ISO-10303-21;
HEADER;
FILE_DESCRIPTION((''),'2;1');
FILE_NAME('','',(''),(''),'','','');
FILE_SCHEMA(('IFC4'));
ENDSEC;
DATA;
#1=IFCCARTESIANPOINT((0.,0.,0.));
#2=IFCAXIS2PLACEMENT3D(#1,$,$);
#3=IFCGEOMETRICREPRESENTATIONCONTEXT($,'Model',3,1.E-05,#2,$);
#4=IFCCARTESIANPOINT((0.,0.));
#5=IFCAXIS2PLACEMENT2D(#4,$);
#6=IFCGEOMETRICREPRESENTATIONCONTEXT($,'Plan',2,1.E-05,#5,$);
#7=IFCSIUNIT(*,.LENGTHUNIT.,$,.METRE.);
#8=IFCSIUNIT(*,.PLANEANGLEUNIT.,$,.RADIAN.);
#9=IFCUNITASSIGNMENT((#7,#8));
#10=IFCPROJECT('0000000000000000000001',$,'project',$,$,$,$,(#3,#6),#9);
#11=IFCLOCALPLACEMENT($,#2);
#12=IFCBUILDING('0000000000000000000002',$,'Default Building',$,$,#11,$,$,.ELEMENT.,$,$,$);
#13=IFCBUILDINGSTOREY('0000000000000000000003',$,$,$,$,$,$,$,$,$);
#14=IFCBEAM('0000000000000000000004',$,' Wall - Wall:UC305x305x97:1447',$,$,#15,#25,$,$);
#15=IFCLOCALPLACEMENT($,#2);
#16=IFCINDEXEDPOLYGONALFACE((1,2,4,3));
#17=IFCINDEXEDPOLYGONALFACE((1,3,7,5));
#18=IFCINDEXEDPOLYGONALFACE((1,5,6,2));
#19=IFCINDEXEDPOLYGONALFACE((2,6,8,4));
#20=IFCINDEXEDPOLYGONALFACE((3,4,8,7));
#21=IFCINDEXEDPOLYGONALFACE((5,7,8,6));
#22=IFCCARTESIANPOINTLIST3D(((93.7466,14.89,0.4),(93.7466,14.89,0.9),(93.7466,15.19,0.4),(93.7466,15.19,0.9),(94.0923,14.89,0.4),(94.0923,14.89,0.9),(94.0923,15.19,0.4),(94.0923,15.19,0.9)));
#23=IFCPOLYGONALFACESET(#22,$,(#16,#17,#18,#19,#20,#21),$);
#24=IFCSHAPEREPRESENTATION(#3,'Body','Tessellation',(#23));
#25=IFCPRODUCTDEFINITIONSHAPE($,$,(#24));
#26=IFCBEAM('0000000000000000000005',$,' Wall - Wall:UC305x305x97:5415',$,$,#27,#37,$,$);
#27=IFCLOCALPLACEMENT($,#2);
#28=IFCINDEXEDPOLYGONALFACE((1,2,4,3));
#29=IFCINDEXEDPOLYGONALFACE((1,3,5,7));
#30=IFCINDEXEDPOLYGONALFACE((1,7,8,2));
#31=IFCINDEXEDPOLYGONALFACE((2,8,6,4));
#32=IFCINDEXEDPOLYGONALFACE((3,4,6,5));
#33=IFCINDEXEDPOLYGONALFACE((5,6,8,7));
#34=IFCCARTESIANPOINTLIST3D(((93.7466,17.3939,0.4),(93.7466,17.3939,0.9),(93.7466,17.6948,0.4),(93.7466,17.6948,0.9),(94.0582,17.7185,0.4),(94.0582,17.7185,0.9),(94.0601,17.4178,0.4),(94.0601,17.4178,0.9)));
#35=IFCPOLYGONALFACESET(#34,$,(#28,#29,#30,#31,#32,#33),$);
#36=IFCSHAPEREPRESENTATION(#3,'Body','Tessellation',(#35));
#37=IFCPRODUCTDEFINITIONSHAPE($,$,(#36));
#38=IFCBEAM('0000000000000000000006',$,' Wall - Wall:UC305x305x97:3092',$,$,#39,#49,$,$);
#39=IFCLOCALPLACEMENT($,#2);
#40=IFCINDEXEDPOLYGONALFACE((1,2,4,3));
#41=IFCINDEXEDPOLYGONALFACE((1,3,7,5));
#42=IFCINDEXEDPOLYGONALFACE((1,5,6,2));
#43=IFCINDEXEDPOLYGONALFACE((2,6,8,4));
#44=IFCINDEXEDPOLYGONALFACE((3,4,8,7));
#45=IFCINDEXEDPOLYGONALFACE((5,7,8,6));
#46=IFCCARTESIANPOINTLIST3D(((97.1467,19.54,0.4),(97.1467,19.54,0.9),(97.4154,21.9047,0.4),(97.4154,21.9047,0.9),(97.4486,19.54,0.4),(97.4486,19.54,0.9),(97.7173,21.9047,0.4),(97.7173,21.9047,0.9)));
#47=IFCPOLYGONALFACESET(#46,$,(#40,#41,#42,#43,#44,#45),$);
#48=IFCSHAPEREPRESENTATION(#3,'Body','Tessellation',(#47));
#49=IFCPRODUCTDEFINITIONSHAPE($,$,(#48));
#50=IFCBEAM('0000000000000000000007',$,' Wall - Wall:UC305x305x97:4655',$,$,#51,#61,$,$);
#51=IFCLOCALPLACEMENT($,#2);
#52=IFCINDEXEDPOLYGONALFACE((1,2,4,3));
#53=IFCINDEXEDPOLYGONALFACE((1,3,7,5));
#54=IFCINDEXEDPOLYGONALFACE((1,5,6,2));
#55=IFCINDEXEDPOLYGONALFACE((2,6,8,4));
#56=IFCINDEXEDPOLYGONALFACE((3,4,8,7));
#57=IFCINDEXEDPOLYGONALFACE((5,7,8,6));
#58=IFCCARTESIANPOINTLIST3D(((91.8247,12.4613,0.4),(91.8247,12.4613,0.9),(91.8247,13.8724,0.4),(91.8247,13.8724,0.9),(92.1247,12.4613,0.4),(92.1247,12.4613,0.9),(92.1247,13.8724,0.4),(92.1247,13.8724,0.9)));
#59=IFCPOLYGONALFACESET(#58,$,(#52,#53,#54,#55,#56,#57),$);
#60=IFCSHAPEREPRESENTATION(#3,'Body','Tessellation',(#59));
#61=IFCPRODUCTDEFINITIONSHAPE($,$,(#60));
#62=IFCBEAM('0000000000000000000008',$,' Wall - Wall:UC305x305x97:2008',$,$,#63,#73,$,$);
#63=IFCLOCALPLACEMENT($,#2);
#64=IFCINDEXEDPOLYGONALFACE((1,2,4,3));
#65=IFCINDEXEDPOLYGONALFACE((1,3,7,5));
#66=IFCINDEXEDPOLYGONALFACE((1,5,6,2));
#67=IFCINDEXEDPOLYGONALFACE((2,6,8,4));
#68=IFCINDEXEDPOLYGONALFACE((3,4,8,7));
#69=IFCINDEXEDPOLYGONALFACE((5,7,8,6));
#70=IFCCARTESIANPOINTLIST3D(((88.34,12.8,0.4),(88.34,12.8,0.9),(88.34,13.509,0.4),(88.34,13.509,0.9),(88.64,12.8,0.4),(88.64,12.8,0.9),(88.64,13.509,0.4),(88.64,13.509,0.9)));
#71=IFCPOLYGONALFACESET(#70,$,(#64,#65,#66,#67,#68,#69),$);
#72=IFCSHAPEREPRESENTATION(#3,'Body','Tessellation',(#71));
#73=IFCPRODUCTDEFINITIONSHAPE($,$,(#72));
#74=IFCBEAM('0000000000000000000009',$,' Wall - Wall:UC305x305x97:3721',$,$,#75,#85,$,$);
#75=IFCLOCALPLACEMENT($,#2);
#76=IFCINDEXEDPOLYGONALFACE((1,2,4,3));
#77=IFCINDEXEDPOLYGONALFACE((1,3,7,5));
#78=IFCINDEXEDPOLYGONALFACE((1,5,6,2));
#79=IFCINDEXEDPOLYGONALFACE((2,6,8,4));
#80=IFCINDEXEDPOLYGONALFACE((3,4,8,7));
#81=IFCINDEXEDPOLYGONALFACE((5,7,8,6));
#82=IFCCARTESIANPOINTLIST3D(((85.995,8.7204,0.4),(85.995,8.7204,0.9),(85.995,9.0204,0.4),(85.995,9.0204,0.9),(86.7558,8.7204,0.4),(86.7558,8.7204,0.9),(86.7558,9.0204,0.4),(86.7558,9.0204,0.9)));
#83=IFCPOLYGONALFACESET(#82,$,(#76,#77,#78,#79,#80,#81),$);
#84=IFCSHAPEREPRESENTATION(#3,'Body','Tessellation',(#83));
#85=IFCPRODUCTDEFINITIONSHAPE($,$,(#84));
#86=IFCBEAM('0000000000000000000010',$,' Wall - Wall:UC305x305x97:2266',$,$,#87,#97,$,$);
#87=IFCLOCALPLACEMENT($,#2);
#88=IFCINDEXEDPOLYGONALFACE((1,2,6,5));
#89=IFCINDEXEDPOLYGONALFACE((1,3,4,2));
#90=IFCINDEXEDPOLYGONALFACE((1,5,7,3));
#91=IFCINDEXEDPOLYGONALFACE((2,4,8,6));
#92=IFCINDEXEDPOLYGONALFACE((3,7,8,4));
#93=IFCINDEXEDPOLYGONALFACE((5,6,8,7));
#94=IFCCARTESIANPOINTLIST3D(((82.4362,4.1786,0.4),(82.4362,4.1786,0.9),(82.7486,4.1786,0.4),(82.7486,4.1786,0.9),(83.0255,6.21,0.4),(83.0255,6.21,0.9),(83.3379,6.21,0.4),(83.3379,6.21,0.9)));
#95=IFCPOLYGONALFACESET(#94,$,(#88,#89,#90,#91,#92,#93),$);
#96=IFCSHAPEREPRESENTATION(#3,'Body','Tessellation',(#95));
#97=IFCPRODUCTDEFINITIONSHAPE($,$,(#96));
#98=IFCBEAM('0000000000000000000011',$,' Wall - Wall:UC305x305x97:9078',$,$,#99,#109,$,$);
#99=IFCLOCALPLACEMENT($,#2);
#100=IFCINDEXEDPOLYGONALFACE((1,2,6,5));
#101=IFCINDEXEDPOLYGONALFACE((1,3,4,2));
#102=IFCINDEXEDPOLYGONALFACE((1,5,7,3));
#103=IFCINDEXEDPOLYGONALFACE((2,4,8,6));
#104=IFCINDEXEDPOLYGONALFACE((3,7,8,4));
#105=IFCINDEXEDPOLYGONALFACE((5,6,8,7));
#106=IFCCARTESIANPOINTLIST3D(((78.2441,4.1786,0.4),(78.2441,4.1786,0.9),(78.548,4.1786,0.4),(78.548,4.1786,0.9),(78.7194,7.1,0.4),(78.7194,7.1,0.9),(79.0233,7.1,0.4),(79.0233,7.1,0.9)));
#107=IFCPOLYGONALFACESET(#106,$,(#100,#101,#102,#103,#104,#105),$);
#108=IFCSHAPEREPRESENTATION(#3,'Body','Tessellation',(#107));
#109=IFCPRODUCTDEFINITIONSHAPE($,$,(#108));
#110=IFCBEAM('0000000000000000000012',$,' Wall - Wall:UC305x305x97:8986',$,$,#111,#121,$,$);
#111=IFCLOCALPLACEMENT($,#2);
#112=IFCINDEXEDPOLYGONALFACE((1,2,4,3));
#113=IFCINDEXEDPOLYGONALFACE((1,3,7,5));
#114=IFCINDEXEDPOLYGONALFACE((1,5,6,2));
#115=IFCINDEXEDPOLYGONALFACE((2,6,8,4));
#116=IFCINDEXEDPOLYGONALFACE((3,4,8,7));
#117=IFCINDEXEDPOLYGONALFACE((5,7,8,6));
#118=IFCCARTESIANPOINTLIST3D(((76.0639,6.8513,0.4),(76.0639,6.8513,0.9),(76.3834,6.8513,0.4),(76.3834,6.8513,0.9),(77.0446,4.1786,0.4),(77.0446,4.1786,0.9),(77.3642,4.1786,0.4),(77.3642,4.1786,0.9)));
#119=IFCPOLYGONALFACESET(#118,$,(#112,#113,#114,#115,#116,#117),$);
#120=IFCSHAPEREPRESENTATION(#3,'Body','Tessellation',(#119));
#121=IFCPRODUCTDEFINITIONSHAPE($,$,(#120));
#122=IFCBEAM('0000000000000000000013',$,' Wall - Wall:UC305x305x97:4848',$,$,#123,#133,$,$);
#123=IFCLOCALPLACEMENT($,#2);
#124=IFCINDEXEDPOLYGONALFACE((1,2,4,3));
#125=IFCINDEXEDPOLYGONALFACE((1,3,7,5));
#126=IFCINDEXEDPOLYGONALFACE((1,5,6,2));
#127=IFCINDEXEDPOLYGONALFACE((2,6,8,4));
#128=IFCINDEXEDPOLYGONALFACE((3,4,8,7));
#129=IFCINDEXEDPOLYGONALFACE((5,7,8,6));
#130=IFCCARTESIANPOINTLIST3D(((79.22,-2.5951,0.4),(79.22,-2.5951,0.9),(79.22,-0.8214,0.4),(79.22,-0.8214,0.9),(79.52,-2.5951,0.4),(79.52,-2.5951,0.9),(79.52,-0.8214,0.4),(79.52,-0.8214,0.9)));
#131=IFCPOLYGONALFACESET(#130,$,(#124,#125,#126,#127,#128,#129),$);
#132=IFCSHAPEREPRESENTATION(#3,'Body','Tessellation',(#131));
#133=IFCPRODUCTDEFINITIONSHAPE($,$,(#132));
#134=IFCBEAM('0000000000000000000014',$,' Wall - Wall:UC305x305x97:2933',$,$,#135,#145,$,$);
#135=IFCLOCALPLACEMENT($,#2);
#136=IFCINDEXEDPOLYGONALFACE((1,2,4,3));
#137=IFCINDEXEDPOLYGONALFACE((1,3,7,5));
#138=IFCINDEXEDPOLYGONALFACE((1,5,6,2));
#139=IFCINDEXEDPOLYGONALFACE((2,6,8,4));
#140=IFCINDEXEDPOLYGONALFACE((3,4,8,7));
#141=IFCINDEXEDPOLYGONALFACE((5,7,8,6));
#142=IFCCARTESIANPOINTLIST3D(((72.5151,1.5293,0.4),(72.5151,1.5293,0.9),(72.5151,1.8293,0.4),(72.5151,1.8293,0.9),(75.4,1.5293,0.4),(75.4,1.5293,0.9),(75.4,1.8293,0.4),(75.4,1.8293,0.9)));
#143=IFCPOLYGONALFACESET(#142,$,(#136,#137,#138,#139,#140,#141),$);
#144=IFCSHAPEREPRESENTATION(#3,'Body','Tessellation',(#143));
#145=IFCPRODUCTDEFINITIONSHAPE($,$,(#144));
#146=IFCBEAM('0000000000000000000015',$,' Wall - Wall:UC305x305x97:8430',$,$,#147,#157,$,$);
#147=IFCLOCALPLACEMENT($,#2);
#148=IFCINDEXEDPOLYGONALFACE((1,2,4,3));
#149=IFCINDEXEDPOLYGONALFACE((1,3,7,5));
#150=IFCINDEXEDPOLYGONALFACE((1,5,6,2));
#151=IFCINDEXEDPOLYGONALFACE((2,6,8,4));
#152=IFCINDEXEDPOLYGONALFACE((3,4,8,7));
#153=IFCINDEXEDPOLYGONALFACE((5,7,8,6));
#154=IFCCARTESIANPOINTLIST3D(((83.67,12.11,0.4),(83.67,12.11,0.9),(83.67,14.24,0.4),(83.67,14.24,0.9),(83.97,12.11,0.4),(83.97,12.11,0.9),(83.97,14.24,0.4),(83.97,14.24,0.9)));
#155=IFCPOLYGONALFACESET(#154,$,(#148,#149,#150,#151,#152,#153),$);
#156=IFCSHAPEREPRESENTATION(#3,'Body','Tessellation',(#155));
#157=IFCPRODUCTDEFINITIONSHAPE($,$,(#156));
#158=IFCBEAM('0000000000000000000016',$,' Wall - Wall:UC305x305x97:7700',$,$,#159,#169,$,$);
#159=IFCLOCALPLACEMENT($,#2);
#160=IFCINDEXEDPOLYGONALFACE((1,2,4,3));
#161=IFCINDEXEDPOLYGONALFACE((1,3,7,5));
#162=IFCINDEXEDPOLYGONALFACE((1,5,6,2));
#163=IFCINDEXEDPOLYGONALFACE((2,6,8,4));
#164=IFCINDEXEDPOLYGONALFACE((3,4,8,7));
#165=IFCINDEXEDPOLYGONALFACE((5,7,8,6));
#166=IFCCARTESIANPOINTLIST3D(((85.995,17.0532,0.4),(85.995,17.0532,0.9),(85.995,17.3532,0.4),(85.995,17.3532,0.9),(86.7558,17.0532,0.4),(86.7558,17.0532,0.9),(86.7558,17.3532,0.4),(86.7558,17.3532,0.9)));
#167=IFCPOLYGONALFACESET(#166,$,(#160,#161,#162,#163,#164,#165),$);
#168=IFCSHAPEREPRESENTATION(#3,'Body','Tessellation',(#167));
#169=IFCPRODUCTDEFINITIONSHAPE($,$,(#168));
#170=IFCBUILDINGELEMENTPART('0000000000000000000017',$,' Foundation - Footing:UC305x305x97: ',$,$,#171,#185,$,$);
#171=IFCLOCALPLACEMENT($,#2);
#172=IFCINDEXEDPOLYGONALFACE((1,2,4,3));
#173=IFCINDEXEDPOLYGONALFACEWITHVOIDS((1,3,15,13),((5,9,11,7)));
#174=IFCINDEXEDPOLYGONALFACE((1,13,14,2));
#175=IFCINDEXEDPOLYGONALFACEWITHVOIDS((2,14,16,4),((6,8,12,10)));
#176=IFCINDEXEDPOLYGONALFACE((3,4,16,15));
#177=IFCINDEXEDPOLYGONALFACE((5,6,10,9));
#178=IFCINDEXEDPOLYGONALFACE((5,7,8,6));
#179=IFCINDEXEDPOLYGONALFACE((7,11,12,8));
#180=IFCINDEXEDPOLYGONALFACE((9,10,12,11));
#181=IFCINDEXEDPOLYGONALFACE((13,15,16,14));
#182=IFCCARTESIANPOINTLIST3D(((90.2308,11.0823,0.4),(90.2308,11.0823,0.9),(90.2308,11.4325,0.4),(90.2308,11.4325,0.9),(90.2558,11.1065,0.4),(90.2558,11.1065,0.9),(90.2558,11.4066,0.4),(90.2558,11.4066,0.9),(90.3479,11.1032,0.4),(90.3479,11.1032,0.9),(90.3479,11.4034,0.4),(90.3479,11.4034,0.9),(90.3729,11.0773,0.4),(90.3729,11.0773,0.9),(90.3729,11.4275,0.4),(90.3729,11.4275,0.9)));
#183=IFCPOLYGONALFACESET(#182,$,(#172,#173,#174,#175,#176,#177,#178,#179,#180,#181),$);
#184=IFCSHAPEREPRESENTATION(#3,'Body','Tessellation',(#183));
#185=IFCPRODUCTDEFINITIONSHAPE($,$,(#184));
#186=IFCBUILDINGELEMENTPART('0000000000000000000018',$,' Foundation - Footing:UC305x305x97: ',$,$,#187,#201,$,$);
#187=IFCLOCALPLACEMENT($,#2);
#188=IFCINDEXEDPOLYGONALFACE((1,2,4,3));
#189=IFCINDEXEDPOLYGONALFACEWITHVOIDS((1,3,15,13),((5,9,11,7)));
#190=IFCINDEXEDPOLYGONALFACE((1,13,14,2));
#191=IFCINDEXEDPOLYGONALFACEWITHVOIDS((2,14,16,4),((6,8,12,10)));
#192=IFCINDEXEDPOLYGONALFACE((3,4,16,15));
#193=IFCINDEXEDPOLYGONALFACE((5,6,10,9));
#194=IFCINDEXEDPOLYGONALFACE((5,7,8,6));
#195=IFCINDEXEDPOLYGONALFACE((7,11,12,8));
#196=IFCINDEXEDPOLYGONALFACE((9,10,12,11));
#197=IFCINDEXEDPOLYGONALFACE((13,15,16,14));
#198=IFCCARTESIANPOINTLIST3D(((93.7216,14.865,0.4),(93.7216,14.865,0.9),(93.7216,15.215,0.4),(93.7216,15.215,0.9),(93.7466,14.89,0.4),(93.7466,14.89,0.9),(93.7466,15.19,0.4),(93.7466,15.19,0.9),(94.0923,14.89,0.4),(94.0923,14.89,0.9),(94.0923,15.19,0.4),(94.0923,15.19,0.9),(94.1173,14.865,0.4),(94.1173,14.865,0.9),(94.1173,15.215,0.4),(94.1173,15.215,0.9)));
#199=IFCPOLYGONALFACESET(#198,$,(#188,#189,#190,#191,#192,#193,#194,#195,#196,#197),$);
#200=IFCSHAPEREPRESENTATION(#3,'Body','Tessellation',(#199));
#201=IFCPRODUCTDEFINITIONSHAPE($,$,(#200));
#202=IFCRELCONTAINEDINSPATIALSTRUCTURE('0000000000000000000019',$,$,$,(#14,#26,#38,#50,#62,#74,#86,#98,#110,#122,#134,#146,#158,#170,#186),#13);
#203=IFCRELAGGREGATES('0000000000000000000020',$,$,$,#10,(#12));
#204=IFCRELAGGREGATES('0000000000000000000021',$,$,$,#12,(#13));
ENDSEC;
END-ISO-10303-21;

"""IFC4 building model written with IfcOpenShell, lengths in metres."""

from ifc_helpers import new_model, si_unit, origin, origin_2d, place, context, project, spatial, polyline, outline, extrude, element, save


model = new_model("IFC4")

# Units and contexts
model_context = context("Model", 3, precision=1e-05, world=origin())
plan_context = context("Plan", 2, precision=1e-05, world=origin_2d())
ifc_project = project(units=[si_unit("LENGTHUNIT", "METRE"), si_unit("PLANEANGLEUNIT", "RADIAN")], contexts=[model_context, plan_context])

# Building, storey
building_placement = place(None, origin())
building = spatial("IfcBuilding", under=ifc_project, at=building_placement, Name="Default Building", CompositionType="ELEMENT")
storey = spatial("IfcBuildingStorey", under=building)

# Beams
element("IfcBeam", 1, inside=storey, Name=" Wall - Wall:UC305x305x97:1447", context=model_context, shape_type="SweptSolid", body=[
    extrude(outline(polyline([(94.0923, 15.19, 0.4), (93.7466, 15.19, 0.4), (93.7466, 14.89, 0.4), (94.0923, 14.89, 0.4), (94.0923, 15.19, 0.4)])), None, (0.0, 0.0, 1.0), 0.5),
])
element("IfcBeam", 2, inside=storey, Name=" Wall - Wall:UC305x305x97:5415", context=model_context, shape_type="SweptSolid", body=[
    extrude(outline(polyline([(94.0601, 17.4178, 0.4), (93.7466, 17.3939, 0.4), (93.7466, 17.6948, 0.4), (94.0582, 17.7185, 0.4), (94.0601, 17.4178, 0.4)])), None, (0.0, 0.0, 1.0), 0.5),
])
element("IfcBeam", 3, inside=storey, Name=" Wall - Wall:UC305x305x97:3092", context=model_context, shape_type="SweptSolid", body=[
    extrude(outline(polyline([(97.4486, 19.54, 0.4), (97.1467, 19.54, 0.4), (97.4154, 21.9047, 0.4), (97.7173, 21.9047, 0.4), (97.4486, 19.54, 0.4)])), None, (0.0, 0.0, 1.0), 0.5),
])
element("IfcBeam", 4, inside=storey, Name=" Wall - Wall:UC305x305x97:4655", context=model_context, shape_type="SweptSolid", body=[
    extrude(outline(polyline([(92.1247, 12.4613, 0.4), (91.8247, 12.4613, 0.4), (91.8247, 13.8724, 0.4), (92.1247, 13.8724, 0.4), (92.1247, 12.4613, 0.4)])), None, (0.0, 0.0, 1.0), 0.5),
])
element("IfcBeam", 5, inside=storey, Name=" Wall - Wall:UC305x305x97:2008", context=model_context, shape_type="SweptSolid", body=[
    extrude(outline(polyline([(88.64, 12.8, 0.4), (88.34, 12.8, 0.4), (88.34, 13.509, 0.4), (88.64, 13.509, 0.4), (88.64, 12.8, 0.4)])), None, (0.0, 0.0, 1.0), 0.5),
])
element("IfcBeam", 6, inside=storey, Name=" Wall - Wall:UC305x305x97:3721", context=model_context, shape_type="SweptSolid", body=[
    extrude(outline(polyline([(86.7558, 8.7204, 0.4), (85.995, 8.7204, 0.4), (85.995, 9.0204, 0.4), (86.7558, 9.0204, 0.4), (86.7558, 8.7204, 0.4)])), None, (0.0, 0.0, 1.0), 0.5),
])
element("IfcBeam", 7, inside=storey, Name=" Wall - Wall:UC305x305x97:2266", context=model_context, shape_type="SweptSolid", body=[
    extrude(outline(polyline([(82.7486, 4.1786, 0.4), (82.4362, 4.1786, 0.4), (83.0255, 6.21, 0.4), (83.3379, 6.21, 0.4), (82.7486, 4.1786, 0.4)])), None, (0.0, 0.0, 1.0), 0.5),
])
element("IfcBeam", 8, inside=storey, Name=" Wall - Wall:UC305x305x97:9078", context=model_context, shape_type="SweptSolid", body=[
    extrude(outline(polyline([(78.548, 4.1786, 0.4), (78.2441, 4.1786, 0.4), (78.7194, 7.1, 0.4), (79.0233, 7.1, 0.4), (78.548, 4.1786, 0.4)])), None, (0.0, 0.0, 1.0), 0.5),
])
element("IfcBeam", 9, inside=storey, Name=" Wall - Wall:UC305x305x97:8986", context=model_context, shape_type="SweptSolid", body=[
    extrude(outline(polyline([(77.3642, 4.1786, 0.4), (77.0446, 4.1786, 0.4), (76.0639, 6.8513, 0.4), (76.3834, 6.8513, 0.4), (77.3642, 4.1786, 0.4)])), None, (0.0, 0.0, 1.0), 0.5),
])
element("IfcBeam", 10, inside=storey, Name=" Wall - Wall:UC305x305x97:4848", context=model_context, shape_type="SweptSolid", body=[
    extrude(outline(polyline([(79.52, -2.5951, 0.4), (79.22, -2.5951, 0.4), (79.22, -0.8214, 0.4), (79.52, -0.8214, 0.4), (79.52, -2.5951, 0.4)])), None, (0.0, 0.0, 1.0), 0.5),
])
element("IfcBeam", 11, inside=storey, Name=" Wall - Wall:UC305x305x97:2933", context=model_context, shape_type="SweptSolid", body=[
    extrude(outline(polyline([(75.4, 1.5293, 0.4), (75.4, 1.8293, 0.4), (72.5151, 1.8293, 0.4), (72.5151, 1.5293, 0.4), (75.4, 1.5293, 0.4)])), None, (0.0, 0.0, 1.0), 0.5),
])
element("IfcBeam", 12, inside=storey, Name=" Wall - Wall:UC305x305x97:8430", context=model_context, shape_type="SweptSolid", body=[
    extrude(outline(polyline([(83.97, 12.11, 0.4), (83.67, 12.11, 0.4), (83.67, 14.24, 0.4), (83.97, 14.24, 0.4), (83.97, 12.11, 0.4)])), None, (0.0, 0.0, 1.0), 0.5),
])
element("IfcBeam", 13, inside=storey, Name=" Wall - Wall:UC305x305x97:7700", context=model_context, shape_type="SweptSolid", body=[
    extrude(outline(polyline([(86.7558, 17.0532, 0.4), (86.7558, 17.3532, 0.4), (85.995, 17.3532, 0.4), (85.995, 17.0532, 0.4), (86.7558, 17.0532, 0.4)])), None, (0.0, 0.0, 1.0), 0.5),
])

# Building element parts, openings
building_element_part_1 = element("IfcBuildingElementPart", 14, inside=storey, Name=" Foundation - Footing:UC305x305x97: ", context=model_context, shape_type="SweptSolid", body=[
    extrude(outline(polyline([(90.3729, 11.0773, 0.4), (90.2308, 11.0823, 0.4), (90.2308, 11.4325, 0.4), (90.3729, 11.4275, 0.4), (90.3729, 11.0773, 0.4)])), None, (0.0, 0.0, 1.0), 0.5),
])
element("IfcOpeningElement", 15, inside=storey, cuts=building_element_part_1, context=model_context, shape_type="SweptSolid", body=[
    extrude(outline(polyline([(90.3479, 11.1032, 0.4), (90.2558, 11.1065, 0.4), (90.2558, 11.4066, 0.4), (90.3479, 11.4034, 0.4), (90.3479, 11.1032, 0.4)])), None, (0.0, 0.0, 1.0), 0.5),
])
building_element_part_2 = element("IfcBuildingElementPart", 16, inside=storey, Name=" Foundation - Footing:UC305x305x97: ", context=model_context, shape_type="SweptSolid", body=[
    extrude(outline(polyline([(94.1173, 15.215, 0.4), (93.7216, 15.215, 0.4), (93.7216, 14.865, 0.4), (94.1173, 14.865, 0.4), (94.1173, 15.215, 0.4)])), None, (0.0, 0.0, 1.0), 0.5),
])
element("IfcOpeningElement", 17, inside=storey, cuts=building_element_part_2, context=model_context, shape_type="SweptSolid", body=[
    extrude(outline(polyline([(94.0923, 15.19, 0.4), (93.7466, 15.19, 0.4), (93.7466, 14.89, 0.4), (94.0923, 14.89, 0.4), (94.0923, 15.19, 0.4)])), None, (0.0, 0.0, 1.0), 0.5),
])

save(model, "model.ifc")
